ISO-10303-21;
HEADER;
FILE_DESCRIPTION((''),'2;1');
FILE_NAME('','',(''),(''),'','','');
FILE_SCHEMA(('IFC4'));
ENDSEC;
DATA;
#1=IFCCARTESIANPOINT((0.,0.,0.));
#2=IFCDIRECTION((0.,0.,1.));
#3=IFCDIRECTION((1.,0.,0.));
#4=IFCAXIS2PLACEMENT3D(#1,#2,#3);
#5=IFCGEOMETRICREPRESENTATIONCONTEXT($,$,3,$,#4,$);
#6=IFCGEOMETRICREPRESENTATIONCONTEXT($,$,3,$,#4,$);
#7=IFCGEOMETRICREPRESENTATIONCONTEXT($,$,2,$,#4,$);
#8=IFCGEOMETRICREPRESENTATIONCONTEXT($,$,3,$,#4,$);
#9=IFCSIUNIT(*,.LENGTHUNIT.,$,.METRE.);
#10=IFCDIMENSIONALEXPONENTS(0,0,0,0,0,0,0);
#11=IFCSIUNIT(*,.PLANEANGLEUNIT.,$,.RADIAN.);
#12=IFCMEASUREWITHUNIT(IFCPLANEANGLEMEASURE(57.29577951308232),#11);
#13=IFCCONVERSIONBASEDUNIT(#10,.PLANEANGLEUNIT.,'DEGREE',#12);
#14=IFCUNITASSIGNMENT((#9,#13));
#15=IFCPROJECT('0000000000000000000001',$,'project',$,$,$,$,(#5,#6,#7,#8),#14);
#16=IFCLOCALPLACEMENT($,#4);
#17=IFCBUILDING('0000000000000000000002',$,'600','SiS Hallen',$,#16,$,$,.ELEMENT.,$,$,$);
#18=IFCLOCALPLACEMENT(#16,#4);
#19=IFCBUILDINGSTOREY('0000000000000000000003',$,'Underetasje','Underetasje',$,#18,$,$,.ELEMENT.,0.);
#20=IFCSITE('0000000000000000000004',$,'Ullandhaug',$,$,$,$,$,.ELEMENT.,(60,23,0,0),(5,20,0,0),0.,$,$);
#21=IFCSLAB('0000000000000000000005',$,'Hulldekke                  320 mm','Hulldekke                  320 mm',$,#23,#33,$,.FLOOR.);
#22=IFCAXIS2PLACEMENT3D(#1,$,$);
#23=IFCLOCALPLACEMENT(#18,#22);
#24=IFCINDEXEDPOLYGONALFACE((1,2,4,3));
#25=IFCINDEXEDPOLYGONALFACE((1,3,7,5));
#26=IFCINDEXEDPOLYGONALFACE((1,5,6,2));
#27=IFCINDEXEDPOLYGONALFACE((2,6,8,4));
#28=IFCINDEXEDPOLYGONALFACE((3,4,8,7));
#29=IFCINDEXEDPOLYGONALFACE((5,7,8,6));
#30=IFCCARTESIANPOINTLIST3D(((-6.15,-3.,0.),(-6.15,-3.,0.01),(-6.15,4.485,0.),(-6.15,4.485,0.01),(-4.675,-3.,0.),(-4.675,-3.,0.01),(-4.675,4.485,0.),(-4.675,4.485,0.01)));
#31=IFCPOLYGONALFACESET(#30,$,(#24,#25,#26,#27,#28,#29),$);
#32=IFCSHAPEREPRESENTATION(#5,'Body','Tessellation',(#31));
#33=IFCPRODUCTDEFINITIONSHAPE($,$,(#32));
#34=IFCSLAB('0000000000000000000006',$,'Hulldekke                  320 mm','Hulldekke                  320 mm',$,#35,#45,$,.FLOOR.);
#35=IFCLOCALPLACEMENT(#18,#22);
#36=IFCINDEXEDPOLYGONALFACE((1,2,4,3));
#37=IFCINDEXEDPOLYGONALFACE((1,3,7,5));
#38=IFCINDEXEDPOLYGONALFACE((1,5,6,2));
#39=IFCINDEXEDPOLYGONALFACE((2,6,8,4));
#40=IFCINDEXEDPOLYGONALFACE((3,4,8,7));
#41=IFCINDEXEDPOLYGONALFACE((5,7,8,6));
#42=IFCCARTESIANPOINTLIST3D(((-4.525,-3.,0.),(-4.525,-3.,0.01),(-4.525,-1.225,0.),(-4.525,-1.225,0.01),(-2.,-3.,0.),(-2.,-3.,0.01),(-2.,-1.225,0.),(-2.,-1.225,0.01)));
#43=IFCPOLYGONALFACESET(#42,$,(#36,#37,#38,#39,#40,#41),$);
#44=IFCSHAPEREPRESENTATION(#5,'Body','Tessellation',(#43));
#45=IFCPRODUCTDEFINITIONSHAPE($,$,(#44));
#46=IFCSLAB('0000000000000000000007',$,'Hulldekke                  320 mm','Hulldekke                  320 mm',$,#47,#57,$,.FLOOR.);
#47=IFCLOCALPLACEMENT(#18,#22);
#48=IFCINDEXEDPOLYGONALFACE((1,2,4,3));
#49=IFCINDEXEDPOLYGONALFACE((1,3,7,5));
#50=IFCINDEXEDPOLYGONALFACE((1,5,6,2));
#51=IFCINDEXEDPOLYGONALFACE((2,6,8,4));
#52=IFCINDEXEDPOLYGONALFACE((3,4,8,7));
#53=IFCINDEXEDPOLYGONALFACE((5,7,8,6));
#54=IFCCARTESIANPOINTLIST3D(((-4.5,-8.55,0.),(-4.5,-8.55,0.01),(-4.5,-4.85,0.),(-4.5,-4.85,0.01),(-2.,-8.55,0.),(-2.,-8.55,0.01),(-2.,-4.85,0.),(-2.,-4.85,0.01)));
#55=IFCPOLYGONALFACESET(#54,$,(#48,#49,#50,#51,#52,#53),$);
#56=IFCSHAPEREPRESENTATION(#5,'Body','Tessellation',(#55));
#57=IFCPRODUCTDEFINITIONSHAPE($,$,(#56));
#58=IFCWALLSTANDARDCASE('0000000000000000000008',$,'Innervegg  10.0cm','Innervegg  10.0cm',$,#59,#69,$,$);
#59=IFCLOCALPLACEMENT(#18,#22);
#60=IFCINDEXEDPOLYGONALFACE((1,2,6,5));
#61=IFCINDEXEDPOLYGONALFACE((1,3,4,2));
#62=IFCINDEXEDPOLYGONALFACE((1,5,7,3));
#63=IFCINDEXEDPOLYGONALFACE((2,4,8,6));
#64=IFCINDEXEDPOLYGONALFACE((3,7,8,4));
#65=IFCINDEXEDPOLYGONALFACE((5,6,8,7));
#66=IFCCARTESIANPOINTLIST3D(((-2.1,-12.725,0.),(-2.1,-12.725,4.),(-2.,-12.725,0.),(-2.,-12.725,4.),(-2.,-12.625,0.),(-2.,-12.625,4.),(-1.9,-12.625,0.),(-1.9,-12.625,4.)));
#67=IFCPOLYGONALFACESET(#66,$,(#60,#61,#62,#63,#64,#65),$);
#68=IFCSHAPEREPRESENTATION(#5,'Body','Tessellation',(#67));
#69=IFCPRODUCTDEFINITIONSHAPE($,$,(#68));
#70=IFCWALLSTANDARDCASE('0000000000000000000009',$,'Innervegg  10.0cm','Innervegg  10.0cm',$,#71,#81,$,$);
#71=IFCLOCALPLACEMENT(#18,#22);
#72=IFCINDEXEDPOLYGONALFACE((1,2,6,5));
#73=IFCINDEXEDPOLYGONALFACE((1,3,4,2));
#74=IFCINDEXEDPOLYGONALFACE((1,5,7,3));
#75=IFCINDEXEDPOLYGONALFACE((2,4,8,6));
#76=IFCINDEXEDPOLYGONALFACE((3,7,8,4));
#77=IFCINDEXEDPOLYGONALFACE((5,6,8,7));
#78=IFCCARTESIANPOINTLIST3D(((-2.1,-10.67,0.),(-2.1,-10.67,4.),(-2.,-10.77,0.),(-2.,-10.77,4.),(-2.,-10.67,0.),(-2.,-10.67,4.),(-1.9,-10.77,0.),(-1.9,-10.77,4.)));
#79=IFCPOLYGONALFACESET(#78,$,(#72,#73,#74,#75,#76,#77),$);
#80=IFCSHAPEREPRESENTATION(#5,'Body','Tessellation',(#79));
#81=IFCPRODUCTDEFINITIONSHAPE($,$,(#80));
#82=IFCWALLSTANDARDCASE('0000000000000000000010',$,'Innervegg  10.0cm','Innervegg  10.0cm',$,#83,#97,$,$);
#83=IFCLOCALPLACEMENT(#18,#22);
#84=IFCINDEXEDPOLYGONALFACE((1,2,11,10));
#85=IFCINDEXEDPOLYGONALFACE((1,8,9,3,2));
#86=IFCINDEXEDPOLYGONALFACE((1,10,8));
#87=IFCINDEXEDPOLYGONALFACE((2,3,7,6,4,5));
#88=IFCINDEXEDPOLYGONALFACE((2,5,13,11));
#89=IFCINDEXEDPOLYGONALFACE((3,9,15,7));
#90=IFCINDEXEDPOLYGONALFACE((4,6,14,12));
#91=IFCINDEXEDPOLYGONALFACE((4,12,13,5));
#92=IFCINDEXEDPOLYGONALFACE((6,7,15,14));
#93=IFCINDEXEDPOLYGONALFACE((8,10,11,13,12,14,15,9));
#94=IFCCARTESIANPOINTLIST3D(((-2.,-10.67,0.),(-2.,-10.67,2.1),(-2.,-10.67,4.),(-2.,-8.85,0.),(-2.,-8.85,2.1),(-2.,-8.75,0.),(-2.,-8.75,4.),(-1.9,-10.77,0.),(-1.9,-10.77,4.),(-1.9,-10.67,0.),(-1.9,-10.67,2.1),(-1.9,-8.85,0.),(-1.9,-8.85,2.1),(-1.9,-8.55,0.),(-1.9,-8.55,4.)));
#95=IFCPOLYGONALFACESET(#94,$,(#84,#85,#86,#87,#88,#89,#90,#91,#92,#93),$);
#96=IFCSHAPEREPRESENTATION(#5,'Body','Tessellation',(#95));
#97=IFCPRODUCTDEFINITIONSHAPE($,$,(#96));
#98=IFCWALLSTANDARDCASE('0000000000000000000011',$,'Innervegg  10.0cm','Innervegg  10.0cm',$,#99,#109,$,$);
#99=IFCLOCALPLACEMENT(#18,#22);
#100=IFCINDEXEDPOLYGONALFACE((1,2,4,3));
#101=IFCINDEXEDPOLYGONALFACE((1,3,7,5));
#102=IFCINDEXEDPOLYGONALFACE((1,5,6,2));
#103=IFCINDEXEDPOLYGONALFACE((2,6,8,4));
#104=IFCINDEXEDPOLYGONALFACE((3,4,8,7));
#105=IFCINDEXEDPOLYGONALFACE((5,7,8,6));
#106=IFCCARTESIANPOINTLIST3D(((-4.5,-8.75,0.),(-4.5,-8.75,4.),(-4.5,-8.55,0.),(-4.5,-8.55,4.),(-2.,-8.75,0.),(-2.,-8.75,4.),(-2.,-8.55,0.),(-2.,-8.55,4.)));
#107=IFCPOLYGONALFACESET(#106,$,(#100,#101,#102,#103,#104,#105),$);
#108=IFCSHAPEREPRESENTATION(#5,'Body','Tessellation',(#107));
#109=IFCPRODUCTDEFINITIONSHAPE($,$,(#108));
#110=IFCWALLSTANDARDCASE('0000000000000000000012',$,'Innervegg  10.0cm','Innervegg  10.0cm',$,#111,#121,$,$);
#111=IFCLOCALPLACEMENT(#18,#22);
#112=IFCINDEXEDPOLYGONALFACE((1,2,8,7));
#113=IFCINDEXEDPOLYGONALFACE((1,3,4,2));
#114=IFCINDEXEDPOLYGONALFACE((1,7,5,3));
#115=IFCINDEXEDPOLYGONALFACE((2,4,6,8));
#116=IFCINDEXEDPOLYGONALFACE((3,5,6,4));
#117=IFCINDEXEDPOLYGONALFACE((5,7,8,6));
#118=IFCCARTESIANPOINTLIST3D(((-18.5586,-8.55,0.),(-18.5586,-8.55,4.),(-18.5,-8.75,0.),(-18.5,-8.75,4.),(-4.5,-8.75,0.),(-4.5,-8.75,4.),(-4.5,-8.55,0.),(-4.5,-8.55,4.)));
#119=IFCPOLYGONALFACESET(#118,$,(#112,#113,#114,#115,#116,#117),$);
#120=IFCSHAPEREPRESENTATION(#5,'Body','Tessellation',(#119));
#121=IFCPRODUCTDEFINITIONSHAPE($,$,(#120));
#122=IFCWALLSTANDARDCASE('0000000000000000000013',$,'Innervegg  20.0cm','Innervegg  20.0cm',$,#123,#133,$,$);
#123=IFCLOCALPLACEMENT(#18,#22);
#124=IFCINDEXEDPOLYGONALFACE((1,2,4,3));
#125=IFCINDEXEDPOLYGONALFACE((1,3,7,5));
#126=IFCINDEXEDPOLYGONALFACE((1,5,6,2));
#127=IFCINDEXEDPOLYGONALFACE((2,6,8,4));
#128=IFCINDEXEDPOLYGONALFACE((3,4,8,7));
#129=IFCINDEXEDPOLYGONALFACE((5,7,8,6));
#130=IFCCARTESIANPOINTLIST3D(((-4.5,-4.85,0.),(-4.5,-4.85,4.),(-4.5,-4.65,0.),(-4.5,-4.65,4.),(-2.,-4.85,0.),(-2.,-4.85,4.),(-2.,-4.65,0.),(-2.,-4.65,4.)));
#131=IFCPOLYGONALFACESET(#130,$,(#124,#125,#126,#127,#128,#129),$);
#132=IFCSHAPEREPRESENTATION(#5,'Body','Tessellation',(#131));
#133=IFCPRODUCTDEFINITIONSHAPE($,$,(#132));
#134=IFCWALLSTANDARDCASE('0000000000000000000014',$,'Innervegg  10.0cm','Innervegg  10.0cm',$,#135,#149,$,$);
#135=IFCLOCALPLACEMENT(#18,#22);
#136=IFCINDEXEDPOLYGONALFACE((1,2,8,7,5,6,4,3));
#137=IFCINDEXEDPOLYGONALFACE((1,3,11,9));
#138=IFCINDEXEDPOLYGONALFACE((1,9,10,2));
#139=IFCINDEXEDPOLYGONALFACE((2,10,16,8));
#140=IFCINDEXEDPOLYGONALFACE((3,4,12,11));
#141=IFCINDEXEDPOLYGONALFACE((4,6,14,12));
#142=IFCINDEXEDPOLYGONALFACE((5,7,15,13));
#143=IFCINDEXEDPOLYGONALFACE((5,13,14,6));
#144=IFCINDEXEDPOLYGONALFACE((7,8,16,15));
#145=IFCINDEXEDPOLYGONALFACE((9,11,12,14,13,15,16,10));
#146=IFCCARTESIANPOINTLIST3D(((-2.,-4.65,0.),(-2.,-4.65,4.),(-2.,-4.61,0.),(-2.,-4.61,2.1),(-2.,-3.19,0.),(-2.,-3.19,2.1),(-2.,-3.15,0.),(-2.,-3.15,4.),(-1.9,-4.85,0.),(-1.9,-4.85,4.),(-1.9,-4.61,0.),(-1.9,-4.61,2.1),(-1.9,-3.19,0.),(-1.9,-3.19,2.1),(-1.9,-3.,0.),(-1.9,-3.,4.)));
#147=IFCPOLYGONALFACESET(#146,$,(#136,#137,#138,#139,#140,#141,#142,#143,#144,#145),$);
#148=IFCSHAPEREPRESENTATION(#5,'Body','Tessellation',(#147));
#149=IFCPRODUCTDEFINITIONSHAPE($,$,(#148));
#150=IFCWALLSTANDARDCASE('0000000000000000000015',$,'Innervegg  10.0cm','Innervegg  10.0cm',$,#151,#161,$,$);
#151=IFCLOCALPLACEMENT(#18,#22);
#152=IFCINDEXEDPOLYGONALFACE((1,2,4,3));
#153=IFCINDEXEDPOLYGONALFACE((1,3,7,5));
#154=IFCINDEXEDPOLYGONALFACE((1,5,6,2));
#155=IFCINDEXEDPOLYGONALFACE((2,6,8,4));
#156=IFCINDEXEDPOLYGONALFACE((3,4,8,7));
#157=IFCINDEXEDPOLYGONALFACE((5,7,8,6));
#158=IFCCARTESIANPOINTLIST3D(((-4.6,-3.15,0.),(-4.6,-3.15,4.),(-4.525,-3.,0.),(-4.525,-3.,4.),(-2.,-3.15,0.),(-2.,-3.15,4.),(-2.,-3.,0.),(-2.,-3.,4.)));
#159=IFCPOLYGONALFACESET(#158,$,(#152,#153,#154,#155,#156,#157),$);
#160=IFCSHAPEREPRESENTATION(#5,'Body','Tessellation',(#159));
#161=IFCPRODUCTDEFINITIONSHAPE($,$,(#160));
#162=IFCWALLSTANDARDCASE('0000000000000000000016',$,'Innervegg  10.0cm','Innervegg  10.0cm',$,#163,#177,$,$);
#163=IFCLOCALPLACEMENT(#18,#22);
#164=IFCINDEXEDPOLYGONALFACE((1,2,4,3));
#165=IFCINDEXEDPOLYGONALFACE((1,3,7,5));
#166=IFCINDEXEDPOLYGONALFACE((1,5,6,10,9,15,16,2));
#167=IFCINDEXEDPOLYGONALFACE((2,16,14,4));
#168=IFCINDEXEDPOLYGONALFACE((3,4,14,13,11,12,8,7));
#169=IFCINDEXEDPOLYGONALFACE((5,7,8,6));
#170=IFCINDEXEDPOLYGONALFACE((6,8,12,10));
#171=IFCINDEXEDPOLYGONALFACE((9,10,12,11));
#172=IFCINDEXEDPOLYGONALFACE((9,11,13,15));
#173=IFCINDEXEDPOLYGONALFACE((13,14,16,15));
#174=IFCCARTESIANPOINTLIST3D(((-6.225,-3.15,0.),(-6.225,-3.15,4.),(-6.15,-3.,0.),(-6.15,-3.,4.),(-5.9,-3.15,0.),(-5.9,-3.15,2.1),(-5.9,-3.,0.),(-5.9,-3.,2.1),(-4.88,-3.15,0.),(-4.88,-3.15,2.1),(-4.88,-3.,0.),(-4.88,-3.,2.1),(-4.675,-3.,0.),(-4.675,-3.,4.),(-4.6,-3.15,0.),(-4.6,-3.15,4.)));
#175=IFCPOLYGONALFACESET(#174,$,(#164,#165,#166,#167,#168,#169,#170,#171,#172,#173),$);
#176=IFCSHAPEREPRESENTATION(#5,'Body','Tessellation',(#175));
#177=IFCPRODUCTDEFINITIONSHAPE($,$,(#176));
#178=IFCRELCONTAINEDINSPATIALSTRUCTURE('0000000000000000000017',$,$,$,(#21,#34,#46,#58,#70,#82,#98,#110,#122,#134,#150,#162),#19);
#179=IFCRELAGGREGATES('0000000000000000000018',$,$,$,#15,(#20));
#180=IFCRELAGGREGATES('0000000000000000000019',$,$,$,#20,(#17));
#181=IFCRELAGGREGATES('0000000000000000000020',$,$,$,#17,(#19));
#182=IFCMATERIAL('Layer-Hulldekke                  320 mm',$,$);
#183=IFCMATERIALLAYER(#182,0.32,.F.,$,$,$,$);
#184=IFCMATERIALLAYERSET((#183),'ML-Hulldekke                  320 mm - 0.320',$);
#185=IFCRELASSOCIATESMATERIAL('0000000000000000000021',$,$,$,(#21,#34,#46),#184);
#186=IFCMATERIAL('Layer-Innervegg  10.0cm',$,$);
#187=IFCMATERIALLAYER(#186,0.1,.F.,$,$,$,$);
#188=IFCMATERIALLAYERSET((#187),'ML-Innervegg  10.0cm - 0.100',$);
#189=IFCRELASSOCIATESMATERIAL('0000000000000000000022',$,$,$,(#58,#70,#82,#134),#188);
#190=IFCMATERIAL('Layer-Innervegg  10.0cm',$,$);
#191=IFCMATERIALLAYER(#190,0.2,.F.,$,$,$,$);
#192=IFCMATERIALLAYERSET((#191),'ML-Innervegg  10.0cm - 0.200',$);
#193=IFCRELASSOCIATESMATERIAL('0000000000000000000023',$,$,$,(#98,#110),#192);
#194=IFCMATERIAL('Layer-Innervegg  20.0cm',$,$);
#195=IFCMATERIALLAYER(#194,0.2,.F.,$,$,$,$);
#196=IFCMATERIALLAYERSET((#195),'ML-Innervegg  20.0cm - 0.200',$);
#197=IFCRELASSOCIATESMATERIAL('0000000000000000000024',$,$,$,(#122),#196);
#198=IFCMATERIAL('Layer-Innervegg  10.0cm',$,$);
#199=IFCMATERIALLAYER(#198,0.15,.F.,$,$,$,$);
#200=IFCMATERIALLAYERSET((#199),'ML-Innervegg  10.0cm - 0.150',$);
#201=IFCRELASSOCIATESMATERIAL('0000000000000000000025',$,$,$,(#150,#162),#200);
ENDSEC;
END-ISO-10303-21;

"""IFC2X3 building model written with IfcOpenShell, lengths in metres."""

from ifc_helpers import new_model, entity, si_unit, converted_unit, frame, origin_with_axes, place, context, project, spatial, polyline, outline, extrude, material, layer, layer_set, layer_usage, element, save


model = new_model("IFC2X3")

# Units and contexts
context_of_model_1 = context(None, 3, world=origin_with_axes())
context_of_model_2 = context(None, 3, world=origin_with_axes())
context_of_model_3 = context(None, 2, world=origin_with_axes())
context_of_model_4 = context(None, 3, world=origin_with_axes())
ifc_project = project(units=[si_unit("LENGTHUNIT", "METRE"), converted_unit("PLANEANGLEUNIT", "DEGREE", entity("IfcPlaneAngleMeasure", 57.29577951308232), si_unit("PLANEANGLEUNIT", "RADIAN"), dimensions=[0, 0, 0, 0, 0, 0, 0])], contexts=[context_of_model_1, context_of_model_2, context_of_model_3, context_of_model_4])

# Site, building, storey
site = spatial("IfcSite", under=ifc_project, Name="Ullandhaug", CompositionType="ELEMENT", RefLatitude=(60, 23, 0, 0), RefLongitude=(5, 20, 0, 0), RefElevation=0.0)
building_placement = place(None, origin_with_axes())
building = spatial("IfcBuilding", under=site, at=building_placement, Name="600", Description="SiS Hallen", CompositionType="ELEMENT")
storey_placement = place(building_placement, origin_with_axes())
storey = spatial("IfcBuildingStorey", under=building, at=storey_placement, Name="Underetasje", Description="Underetasje", CompositionType="ELEMENT", Elevation=0.0)

# Slabs
ifc_material_1 = material(Name="Layer-Hulldekke                  320 mm")
ifc_layer_1 = layer(ifc_material_1, 0.32, ventilated=False)
ifc_layer_set_1 = layer_set([ifc_layer_1], Name="ML-Hulldekke                  320 mm - 0.320")
ifc_layer_usage_1 = layer_usage(ifc_layer_set_1, "AXIS2", "POSITIVE", 0.0)
slab_1_placement = place(storey_placement, frame((-6.15, -3.0, 0.0), z_axis=(0.0, 0.0, 1.0), x_axis=(1.0, 0.0, 0.0)))
element("IfcSlab", 1, at=slab_1_placement, inside=storey, material=ifc_layer_usage_1, Name="Hulldekke                  320 mm", Description="Hulldekke                  320 mm", PredefinedType="FLOOR", context=context_of_model_1, shape_type="SweptSolid", body=[
    extrude(outline(polyline([(0.0, 0.0), (1.475, 0.0), (1.475, 7.485), (0.0, 7.485), (0.0, 0.0)])), origin_with_axes(), (0.0, 0.0, 1.0), 0.01),
])
slab_2_placement = place(storey_placement, frame((-4.525, -3.0, 0.0), z_axis=(0.0, 0.0, 1.0), x_axis=(1.0, 0.0, 0.0)))
element("IfcSlab", 2, at=slab_2_placement, inside=storey, material=ifc_layer_usage_1, Name="Hulldekke                  320 mm", Description="Hulldekke                  320 mm", PredefinedType="FLOOR", context=context_of_model_1, shape_type="SweptSolid", body=[
    extrude(outline(polyline([(0.0, 0.0), (2.525, 0.0), (2.525, 1.775), (0.0, 1.775), (0.0, 0.0)])), origin_with_axes(), (0.0, 0.0, 1.0), 0.01),
])
slab_3_placement = place(storey_placement, frame((-4.5, -8.55, 0.0), z_axis=(0.0, 0.0, 1.0), x_axis=(1.0, 0.0, 0.0)))
element("IfcSlab", 3, at=slab_3_placement, inside=storey, material=ifc_layer_usage_1, Name="Hulldekke                  320 mm", Description="Hulldekke                  320 mm", PredefinedType="FLOOR", context=context_of_model_1, shape_type="SweptSolid", body=[
    extrude(outline(polyline([(0.0, 0.0), (2.5, 0.0), (2.5, 3.7), (0.0, 3.7), (0.0, 0.0)])), origin_with_axes(), (0.0, 0.0, 1.0), 0.01),
])

# Walls
ifc_material_2 = material(Name="Layer-Innervegg  10.0cm")
ifc_layer_2 = layer(ifc_material_2, 0.1, ventilated=False)
ifc_layer_set_2 = layer_set([ifc_layer_2], Name="ML-Innervegg  10.0cm - 0.100")
ifc_layer_usage_2 = layer_usage(ifc_layer_set_2, "AXIS2", "POSITIVE", 0.0)
wall_1_placement = place(storey_placement, frame((-1.9, -12.625, 0.0), z_axis=(0.0, 0.0, 1.0), x_axis=(-1.0, 0.0, 0.0)))
element("IfcWallStandardCase", 4, at=wall_1_placement, inside=storey, material=ifc_layer_usage_2, Name="Innervegg  10.0cm", Description="Innervegg  10.0cm", context=context_of_model_1, shape_type="SweptSolid", body=[
    extrude(outline(polyline([(0.0, 0.0), (0.1, 0.0), (0.2, 0.1), (0.1, 0.1), (0.0, 0.0)])), frame((0.0, 0.0, 0.0), z_axis=(0.0, 0.0, 1.0), x_axis=(1.0, 0.0, 0.0)), (0.0, 0.0, 1.0), 4.0),
])
wall_2_placement = place(storey_placement, frame((-2.0, -10.77, 0.0), z_axis=(0.0, 0.0, 1.0), x_axis=(1.0, 0.0, 0.0)))
element("IfcWallStandardCase", 5, at=wall_2_placement, inside=storey, material=ifc_layer_usage_2, Name="Innervegg  10.0cm", Description="Innervegg  10.0cm", context=context_of_model_1, shape_type="SweptSolid", body=[
    extrude(outline(polyline([(0.0, 0.0), (0.1, 0.0), (0.0, 0.1), (-0.1, 0.1), (0.0, 0.0)])), origin_with_axes(), (0.0, 0.0, 1.0), 4.0),
])

# Wall, opening
wall_3_placement = place(storey_placement, frame((-1.9, -10.77, 0.0), z_axis=(0.0, 0.0, 1.0), x_axis=(0.0, 1.0, 0.0)))
wall_3 = element("IfcWallStandardCase", 6, at=wall_3_placement, inside=storey, material=ifc_layer_usage_2, Name="Innervegg  10.0cm", Description="Innervegg  10.0cm", context=context_of_model_1, shape_type="SweptSolid", body=[
    extrude(outline(polyline([(0.0, 0.0), (2.22, 0.0), (2.02, 0.1), (0.1, 0.1), (0.0, 0.0)])), frame((0.0, 0.0, 0.0), z_axis=(0.0, 0.0, 1.0), x_axis=(1.0, 0.0, 0.0)), (0.0, 0.0, 1.0), 4.0),
])
opening_1_placement = place(wall_3_placement, frame((0.1, 0.1, 0.0), z_axis=(0.0, 0.0, 1.0), x_axis=(1.0, 0.0, 0.0)))
element("IfcOpeningElement", 7, at=opening_1_placement, cuts=wall_3, context=context_of_model_1, shape_type="SweptSolid", body=[
    extrude(outline(polyline([(0.0, 0.0), (2.1, 0.0), (2.1, 1.82), (0.0, 1.82), (0.0, 0.0)])), frame((0.0, 0.0, 0.0), z_axis=(0.0, 1.0, 0.0), x_axis=(0.0, 0.0, 1.0)), (0.0, 0.0, -1.0), 0.1),
])

# Walls
ifc_material_3 = material(Name="Layer-Innervegg  10.0cm")
ifc_layer_3 = layer(ifc_material_3, 0.2, ventilated=False)
ifc_layer_set_3 = layer_set([ifc_layer_3], Name="ML-Innervegg  10.0cm - 0.200")
ifc_layer_usage_3 = layer_usage(ifc_layer_set_3, "AXIS2", "POSITIVE", 0.0)
wall_4_placement = place(storey_placement, frame((-2.0, -8.55, 0.0), z_axis=(0.0, 0.0, 1.0), x_axis=(-1.0, 0.0, 0.0)))
element("IfcWallStandardCase", 8, at=wall_4_placement, inside=storey, material=ifc_layer_usage_3, Name="Innervegg  10.0cm", Description="Innervegg  10.0cm", context=context_of_model_1, shape_type="SweptSolid", body=[
    extrude(outline(polyline([(0.0, 0.0), (2.5, 0.0), (2.5, 0.2), (0.0, 0.2), (0.0, 0.0)])), frame((0.0, 0.0, 0.0), z_axis=(0.0, 0.0, 1.0), x_axis=(1.0, 0.0, 0.0)), (0.0, 0.0, 1.0), 4.0),
])
wall_5_placement = place(storey_placement, frame((-4.5, -8.55, 0.0), z_axis=(0.0, 0.0, 1.0), x_axis=(-1.0, 0.0, 0.0)))
element("IfcWallStandardCase", 9, at=wall_5_placement, inside=storey, material=ifc_layer_usage_3, Name="Innervegg  10.0cm", Description="Innervegg  10.0cm", context=context_of_model_1, shape_type="SweptSolid", body=[
    extrude(outline(polyline([(0.0, 0.0), (14.0586, 0.0), (14.0, 0.2), (0.0, 0.2), (0.0, 0.0)])), frame((0.0, 0.0, 0.0), z_axis=(0.0, 0.0, 1.0), x_axis=(1.0, 0.0, 0.0)), (0.0, 0.0, 1.0), 4.0),
])
ifc_material_4 = material(Name="Layer-Innervegg  20.0cm")
ifc_layer_4 = layer(ifc_material_4, 0.2, ventilated=False)
ifc_layer_set_4 = layer_set([ifc_layer_4], Name="ML-Innervegg  20.0cm - 0.200")
ifc_layer_usage_4 = layer_usage(ifc_layer_set_4, "AXIS2", "POSITIVE", 0.0)
wall_6_placement = place(storey_placement, frame((-4.5, -4.85, 0.0), z_axis=(0.0, 0.0, 1.0), x_axis=(1.0, 0.0, 0.0)))
element("IfcWallStandardCase", 10, at=wall_6_placement, inside=storey, material=ifc_layer_usage_4, Name="Innervegg  20.0cm", Description="Innervegg  20.0cm", context=context_of_model_1, shape_type="SweptSolid", body=[
    extrude(outline(polyline([(0.0, 0.0), (2.5, 0.0), (2.5, 0.2), (0.0, 0.2), (0.0, 0.0)])), origin_with_axes(), (0.0, 0.0, 1.0), 4.0),
])

# Wall, opening
wall_7_placement = place(storey_placement, frame((-1.9, -4.85, 0.0), z_axis=(0.0, 0.0, 1.0), x_axis=(0.0, 1.0, 0.0)))
wall_7 = element("IfcWallStandardCase", 11, at=wall_7_placement, inside=storey, material=ifc_layer_usage_2, Name="Innervegg  10.0cm", Description="Innervegg  10.0cm", context=context_of_model_1, shape_type="SweptSolid", body=[
    extrude(outline(polyline([(0.0, 0.0), (1.85, 0.0), (1.7, 0.1), (0.2, 0.1), (0.0, 0.0)])), frame((0.0, 0.0, 0.0), z_axis=(0.0, 0.0, 1.0), x_axis=(1.0, 0.0, 0.0)), (0.0, 0.0, 1.0), 4.0),
])
opening_2_placement = place(wall_7_placement, frame((0.24, 0.1, 0.0), z_axis=(0.0, 0.0, 1.0), x_axis=(1.0, 0.0, 0.0)))
element("IfcOpeningElement", 12, at=opening_2_placement, cuts=wall_7, context=context_of_model_1, shape_type="SweptSolid", body=[
    extrude(outline(polyline([(0.0, 0.0), (2.1, 0.0), (2.1, 1.42), (0.0, 1.42), (0.0, 0.0)])), frame((0.0, 0.0, 0.0), z_axis=(0.0, 1.0, 0.0), x_axis=(0.0, 0.0, 1.0)), (0.0, 0.0, -1.0), 0.1),
])

# Wall
ifc_material_5 = material(Name="Layer-Innervegg  10.0cm")
ifc_layer_5 = layer(ifc_material_5, 0.15, ventilated=False)
ifc_layer_set_5 = layer_set([ifc_layer_5], Name="ML-Innervegg  10.0cm - 0.150")
ifc_layer_usage_5 = layer_usage(ifc_layer_set_5, "AXIS2", "POSITIVE", 0.0)
wall_8_placement = place(storey_placement, frame((-2.0, -3.0, 0.0), z_axis=(0.0, 0.0, 1.0), x_axis=(-1.0, 0.0, 0.0)))
element("IfcWallStandardCase", 13, at=wall_8_placement, inside=storey, material=ifc_layer_usage_5, Name="Innervegg  10.0cm", Description="Innervegg  10.0cm", context=context_of_model_1, shape_type="SweptSolid", body=[
    extrude(outline(polyline([(0.0, 0.0), (2.525, 0.0), (2.6, 0.15), (0.0, 0.15), (0.0, 0.0)])), frame((0.0, 0.0, 0.0), z_axis=(0.0, 0.0, 1.0), x_axis=(1.0, 0.0, 0.0)), (0.0, 0.0, 1.0), 4.0),
])

# Wall, opening
wall_9_placement = place(storey_placement, frame((-4.675, -3.0, 0.0), z_axis=(0.0, 0.0, 1.0), x_axis=(-1.0, 0.0, 0.0)))
wall_9 = element("IfcWallStandardCase", 14, at=wall_9_placement, inside=storey, material=ifc_layer_usage_5, Name="Innervegg  10.0cm", Description="Innervegg  10.0cm", context=context_of_model_1, shape_type="SweptSolid", body=[
    extrude(outline(polyline([(0.0, 0.0), (1.475, 0.0), (1.55, 0.15), (-0.075, 0.15), (0.0, 0.0)])), frame((0.0, 0.0, 0.0), z_axis=(0.0, 0.0, 1.0), x_axis=(1.0, 0.0, 0.0)), (0.0, 0.0, 1.0), 4.0),
])
opening_3_placement = place(wall_9_placement, frame((0.205, 0.15, 0.0), z_axis=(0.0, 0.0, 1.0), x_axis=(1.0, 0.0, 0.0)))
element("IfcOpeningElement", 15, at=opening_3_placement, cuts=wall_9, context=context_of_model_1, shape_type="SweptSolid", body=[
    extrude(outline(polyline([(0.0, 0.0), (2.1, 0.0), (2.1, 1.02), (0.0, 1.02), (0.0, 0.0)])), frame((0.0, 0.0, 0.0), z_axis=(0.0, 1.0, 0.0), x_axis=(0.0, 0.0, 1.0)), (0.0, 0.0, -1.0), 0.15),
])

save(model, "model.ifc")
